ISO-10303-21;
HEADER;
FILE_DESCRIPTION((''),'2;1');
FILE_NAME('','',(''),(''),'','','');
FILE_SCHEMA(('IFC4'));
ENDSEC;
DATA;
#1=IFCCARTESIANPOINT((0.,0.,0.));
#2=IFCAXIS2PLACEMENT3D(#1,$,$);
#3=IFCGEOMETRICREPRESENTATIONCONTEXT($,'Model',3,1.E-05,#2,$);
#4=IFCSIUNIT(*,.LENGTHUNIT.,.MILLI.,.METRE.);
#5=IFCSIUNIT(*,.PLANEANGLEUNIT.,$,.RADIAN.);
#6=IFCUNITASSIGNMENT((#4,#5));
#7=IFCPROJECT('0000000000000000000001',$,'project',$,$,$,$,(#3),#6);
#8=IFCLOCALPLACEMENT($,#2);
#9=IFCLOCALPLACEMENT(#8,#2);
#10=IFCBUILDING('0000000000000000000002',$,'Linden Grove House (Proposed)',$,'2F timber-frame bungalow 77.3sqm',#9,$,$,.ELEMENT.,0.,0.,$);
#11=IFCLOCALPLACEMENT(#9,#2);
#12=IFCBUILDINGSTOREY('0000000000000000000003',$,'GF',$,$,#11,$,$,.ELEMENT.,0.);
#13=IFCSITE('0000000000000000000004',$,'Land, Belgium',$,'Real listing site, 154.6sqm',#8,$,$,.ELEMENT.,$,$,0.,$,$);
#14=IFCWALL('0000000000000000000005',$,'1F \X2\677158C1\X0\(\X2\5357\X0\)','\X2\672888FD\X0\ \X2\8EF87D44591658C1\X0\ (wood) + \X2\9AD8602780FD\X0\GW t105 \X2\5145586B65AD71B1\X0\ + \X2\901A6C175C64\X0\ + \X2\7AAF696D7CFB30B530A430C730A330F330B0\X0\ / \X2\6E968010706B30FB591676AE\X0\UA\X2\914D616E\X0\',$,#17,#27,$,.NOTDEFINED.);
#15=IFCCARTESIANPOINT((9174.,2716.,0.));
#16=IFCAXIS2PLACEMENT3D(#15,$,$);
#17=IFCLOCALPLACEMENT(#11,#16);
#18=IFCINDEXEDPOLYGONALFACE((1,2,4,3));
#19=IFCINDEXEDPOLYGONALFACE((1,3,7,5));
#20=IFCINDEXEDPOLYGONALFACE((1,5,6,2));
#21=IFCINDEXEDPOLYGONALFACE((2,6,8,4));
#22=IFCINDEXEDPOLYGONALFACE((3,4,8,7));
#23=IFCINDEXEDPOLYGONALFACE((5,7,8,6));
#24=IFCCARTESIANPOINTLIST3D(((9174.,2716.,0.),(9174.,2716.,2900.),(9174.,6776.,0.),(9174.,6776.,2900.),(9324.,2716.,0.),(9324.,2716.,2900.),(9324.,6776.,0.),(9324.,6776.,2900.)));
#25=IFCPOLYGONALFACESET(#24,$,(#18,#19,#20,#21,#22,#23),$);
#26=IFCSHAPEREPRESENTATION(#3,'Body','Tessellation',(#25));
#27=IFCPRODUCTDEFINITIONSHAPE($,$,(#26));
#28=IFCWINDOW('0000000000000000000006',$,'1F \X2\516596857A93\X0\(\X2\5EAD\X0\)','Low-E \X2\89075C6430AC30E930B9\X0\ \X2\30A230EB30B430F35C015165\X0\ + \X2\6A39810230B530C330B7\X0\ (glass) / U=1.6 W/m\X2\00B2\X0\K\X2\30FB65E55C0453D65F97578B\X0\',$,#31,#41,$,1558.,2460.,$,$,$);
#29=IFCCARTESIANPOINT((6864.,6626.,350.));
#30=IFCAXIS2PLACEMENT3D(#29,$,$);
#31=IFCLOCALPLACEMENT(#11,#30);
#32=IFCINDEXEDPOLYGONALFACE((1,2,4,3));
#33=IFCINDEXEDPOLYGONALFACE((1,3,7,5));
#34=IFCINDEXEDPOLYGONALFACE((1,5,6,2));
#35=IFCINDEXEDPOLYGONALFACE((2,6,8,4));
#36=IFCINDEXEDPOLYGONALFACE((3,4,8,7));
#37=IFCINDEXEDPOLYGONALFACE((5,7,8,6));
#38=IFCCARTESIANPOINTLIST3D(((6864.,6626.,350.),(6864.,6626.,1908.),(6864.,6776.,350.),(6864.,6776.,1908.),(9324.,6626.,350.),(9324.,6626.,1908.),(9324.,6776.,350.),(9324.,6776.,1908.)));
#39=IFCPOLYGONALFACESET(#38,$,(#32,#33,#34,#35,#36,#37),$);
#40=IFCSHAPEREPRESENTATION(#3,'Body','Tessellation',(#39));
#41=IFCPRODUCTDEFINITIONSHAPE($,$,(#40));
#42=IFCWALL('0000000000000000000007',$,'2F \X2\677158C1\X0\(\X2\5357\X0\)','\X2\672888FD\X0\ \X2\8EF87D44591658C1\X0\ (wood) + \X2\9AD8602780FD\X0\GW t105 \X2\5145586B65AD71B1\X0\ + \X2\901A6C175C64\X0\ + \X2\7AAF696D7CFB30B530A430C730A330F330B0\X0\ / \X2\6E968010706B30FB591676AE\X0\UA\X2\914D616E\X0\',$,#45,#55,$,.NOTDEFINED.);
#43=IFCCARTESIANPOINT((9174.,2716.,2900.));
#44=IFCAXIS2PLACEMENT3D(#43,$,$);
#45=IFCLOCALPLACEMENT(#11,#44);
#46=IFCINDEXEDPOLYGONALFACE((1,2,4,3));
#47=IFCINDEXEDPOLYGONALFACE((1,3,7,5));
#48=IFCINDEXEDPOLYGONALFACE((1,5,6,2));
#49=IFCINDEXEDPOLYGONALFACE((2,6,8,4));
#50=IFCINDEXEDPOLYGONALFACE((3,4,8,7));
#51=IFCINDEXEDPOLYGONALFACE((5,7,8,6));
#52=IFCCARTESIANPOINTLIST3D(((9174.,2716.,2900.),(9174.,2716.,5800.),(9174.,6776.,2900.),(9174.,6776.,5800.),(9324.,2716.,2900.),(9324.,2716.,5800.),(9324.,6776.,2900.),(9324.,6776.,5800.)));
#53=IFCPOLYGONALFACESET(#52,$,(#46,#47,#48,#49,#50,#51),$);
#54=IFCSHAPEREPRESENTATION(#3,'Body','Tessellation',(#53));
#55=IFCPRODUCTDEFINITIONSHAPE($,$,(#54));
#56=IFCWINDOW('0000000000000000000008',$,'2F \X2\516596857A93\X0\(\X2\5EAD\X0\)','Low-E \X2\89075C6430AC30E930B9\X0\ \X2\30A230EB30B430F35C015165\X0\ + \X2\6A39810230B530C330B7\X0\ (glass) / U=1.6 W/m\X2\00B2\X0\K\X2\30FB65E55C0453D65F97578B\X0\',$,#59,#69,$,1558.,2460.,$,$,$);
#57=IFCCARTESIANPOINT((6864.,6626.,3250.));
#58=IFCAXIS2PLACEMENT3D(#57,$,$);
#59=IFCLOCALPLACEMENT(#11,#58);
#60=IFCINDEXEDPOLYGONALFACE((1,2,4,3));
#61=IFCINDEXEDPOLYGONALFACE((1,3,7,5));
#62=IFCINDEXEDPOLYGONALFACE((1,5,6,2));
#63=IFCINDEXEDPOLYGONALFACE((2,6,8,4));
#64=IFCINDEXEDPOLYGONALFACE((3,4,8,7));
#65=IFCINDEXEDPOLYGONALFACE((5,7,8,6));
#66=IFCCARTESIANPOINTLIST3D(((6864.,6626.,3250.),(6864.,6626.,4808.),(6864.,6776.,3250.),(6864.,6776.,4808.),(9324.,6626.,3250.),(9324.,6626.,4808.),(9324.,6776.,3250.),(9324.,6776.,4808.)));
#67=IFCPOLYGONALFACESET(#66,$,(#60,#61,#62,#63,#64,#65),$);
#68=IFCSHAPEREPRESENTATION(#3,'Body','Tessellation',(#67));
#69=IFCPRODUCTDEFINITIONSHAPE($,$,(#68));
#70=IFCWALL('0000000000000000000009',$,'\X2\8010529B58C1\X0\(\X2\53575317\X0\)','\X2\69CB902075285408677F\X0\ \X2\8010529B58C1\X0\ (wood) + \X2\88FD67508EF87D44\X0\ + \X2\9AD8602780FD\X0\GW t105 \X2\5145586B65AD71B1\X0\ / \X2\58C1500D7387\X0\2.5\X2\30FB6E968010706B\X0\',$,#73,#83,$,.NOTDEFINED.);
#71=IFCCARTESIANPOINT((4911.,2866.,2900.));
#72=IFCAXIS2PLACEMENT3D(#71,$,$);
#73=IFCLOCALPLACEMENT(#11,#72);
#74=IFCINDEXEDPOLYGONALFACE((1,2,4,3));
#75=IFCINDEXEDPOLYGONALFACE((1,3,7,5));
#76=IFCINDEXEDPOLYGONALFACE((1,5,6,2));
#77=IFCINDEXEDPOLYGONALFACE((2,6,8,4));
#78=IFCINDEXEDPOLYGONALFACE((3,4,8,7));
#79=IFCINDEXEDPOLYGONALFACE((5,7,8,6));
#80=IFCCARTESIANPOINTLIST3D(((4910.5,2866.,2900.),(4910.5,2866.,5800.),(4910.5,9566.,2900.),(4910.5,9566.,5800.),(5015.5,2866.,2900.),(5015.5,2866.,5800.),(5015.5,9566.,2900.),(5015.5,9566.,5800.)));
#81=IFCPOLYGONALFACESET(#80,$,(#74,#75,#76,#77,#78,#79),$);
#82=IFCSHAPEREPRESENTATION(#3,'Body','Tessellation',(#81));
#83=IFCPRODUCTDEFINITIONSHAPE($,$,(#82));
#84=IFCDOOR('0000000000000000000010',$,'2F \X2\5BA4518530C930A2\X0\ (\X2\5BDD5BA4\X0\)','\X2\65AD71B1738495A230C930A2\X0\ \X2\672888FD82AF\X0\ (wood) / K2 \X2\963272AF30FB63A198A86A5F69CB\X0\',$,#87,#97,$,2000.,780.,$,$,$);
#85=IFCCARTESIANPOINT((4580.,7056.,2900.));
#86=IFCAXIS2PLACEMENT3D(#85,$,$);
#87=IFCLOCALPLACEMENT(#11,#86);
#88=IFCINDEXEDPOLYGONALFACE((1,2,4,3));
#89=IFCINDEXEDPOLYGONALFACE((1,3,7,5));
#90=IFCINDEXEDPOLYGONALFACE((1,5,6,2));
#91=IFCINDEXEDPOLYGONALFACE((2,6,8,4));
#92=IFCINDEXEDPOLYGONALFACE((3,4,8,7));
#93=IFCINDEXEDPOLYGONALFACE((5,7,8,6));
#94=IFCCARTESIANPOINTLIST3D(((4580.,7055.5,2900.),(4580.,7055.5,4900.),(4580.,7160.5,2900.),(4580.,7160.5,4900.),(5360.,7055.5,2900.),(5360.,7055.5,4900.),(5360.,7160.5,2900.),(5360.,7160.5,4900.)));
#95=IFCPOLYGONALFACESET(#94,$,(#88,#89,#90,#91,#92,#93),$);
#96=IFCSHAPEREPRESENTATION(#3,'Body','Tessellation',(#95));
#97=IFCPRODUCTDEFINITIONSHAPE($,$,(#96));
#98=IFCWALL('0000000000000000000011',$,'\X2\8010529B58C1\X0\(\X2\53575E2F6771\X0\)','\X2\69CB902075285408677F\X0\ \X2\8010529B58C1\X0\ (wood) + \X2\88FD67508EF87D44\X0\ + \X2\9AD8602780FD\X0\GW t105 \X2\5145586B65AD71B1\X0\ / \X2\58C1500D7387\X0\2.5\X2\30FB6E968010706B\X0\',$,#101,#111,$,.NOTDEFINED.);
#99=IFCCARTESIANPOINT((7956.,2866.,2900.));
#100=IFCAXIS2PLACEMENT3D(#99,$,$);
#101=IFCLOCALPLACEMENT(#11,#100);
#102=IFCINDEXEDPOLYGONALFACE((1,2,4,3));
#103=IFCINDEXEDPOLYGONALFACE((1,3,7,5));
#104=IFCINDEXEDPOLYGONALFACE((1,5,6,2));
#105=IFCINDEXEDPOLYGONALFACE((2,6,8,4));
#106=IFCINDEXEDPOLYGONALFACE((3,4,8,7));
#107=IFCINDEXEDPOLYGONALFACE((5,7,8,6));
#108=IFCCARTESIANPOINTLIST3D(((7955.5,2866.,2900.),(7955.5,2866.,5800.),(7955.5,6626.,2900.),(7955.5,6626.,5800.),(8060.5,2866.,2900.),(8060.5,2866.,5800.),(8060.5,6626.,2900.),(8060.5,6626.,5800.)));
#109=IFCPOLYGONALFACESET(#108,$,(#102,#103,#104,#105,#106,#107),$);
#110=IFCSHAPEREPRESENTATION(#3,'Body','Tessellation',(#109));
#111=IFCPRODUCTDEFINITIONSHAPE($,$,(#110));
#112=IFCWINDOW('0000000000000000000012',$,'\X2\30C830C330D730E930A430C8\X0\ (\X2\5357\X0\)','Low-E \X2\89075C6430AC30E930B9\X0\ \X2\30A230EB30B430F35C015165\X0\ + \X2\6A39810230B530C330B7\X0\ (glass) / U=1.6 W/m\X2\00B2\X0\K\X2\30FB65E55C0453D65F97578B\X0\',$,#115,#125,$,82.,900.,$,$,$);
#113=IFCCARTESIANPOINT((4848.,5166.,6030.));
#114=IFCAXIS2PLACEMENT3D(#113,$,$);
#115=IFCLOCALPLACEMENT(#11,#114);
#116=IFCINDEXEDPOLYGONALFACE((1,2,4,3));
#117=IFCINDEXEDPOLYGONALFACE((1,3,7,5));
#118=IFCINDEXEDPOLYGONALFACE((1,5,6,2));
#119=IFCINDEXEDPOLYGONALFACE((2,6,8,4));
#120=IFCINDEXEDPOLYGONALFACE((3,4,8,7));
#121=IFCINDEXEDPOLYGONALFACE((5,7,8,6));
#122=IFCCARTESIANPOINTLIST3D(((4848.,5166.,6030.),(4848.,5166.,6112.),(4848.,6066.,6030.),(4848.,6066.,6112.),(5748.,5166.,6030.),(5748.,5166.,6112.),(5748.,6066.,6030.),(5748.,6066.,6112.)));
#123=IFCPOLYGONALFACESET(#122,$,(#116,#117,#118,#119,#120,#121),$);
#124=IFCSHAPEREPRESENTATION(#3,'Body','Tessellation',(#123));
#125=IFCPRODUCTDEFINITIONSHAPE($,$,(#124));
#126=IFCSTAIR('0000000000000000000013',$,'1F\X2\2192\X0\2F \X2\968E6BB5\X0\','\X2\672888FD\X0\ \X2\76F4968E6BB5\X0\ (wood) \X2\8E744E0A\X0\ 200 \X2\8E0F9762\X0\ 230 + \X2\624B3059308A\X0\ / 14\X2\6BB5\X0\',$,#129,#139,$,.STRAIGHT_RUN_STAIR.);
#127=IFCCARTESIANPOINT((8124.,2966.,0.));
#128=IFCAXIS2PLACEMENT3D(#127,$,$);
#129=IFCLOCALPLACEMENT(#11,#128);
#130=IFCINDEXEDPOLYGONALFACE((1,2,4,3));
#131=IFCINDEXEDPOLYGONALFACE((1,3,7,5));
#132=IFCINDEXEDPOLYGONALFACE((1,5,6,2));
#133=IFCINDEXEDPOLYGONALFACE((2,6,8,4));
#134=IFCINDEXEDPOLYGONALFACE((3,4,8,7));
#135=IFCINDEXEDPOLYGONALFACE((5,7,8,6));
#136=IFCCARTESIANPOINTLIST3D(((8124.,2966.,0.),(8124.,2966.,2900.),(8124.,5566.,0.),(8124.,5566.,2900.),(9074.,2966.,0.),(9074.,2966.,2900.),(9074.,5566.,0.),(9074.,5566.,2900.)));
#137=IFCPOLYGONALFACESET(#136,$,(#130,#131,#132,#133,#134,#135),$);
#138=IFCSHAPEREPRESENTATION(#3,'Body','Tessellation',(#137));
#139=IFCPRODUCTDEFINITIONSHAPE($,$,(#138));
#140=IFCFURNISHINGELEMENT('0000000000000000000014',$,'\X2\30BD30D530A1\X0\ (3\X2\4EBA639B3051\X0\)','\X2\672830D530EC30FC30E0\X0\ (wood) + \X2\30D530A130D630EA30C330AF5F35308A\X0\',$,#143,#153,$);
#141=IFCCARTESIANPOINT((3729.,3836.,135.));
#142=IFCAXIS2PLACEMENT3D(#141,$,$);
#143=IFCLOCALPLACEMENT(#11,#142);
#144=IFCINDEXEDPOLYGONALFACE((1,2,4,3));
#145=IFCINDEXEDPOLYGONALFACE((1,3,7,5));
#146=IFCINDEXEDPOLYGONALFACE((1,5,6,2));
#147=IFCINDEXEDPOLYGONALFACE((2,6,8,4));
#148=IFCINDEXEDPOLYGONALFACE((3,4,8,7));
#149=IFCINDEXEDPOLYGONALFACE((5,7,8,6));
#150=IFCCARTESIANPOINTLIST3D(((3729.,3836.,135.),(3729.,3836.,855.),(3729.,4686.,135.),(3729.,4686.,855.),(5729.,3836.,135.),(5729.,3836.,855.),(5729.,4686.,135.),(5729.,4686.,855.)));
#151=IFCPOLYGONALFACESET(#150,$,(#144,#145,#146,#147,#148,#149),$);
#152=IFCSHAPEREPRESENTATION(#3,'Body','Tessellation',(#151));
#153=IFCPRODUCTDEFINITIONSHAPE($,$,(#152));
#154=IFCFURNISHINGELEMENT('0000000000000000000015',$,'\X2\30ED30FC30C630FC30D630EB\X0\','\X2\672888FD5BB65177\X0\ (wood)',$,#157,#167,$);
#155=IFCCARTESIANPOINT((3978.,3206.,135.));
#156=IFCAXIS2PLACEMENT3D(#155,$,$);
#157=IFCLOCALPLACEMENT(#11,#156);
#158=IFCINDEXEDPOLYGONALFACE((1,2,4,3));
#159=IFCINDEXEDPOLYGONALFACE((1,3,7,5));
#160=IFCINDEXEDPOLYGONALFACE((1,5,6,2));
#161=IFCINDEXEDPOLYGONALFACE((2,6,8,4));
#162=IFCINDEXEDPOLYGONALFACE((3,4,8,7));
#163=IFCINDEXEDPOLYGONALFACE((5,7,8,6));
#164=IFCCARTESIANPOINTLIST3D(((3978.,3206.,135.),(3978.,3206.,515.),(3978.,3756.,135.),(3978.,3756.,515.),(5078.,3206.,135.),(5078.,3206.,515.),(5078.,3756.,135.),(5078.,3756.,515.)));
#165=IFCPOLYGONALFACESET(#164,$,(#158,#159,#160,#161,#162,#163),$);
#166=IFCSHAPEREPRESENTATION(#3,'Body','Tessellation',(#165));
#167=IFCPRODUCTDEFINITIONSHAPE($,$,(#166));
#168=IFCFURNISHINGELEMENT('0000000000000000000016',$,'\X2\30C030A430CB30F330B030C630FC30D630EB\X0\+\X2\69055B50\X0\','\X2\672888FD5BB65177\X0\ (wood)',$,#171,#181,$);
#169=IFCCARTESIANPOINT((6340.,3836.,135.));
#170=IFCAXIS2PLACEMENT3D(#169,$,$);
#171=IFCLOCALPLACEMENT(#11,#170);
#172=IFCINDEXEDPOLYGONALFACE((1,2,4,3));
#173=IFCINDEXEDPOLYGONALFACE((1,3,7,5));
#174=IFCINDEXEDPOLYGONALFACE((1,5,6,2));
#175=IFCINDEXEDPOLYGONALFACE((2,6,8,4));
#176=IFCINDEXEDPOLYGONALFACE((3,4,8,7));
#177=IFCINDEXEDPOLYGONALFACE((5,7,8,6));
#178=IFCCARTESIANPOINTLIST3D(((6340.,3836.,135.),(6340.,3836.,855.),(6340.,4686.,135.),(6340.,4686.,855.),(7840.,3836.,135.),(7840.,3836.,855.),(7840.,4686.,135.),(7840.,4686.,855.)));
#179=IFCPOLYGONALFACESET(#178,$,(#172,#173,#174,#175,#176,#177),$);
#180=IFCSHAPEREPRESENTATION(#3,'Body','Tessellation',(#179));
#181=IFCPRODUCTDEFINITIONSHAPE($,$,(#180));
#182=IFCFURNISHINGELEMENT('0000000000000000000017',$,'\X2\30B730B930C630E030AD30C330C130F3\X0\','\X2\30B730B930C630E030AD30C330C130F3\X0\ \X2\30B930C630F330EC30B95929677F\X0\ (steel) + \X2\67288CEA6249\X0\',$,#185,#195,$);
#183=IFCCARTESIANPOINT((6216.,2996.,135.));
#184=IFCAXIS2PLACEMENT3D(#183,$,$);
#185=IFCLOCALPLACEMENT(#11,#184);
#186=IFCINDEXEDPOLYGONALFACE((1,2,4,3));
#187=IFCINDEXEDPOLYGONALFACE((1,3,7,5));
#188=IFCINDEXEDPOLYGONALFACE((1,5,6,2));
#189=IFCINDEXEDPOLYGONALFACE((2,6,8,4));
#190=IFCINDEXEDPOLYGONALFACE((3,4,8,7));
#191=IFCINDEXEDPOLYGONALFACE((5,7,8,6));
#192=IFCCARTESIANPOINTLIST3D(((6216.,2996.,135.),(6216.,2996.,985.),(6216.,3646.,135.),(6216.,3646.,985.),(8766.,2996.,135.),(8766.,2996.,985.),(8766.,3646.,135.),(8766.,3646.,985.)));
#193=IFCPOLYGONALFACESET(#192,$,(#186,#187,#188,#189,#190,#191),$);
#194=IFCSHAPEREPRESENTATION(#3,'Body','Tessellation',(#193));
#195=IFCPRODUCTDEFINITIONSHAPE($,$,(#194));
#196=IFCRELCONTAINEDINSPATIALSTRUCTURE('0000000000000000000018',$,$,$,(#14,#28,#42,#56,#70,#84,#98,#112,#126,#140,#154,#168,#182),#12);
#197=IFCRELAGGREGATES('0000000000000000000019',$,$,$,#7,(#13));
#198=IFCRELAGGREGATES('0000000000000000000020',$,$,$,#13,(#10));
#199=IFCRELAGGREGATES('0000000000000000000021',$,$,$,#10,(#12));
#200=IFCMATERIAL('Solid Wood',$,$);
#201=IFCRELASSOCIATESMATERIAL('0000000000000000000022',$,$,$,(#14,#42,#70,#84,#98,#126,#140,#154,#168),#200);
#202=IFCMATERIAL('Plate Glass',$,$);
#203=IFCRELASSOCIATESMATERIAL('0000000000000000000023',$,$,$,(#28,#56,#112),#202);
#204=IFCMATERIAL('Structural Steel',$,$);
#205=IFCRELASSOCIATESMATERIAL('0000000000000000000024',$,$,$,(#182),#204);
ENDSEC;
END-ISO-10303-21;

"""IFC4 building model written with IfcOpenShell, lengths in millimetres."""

from ifc_helpers import new_model, si_unit, frame, frame_2d, origin, place, context, project, spatial, rectangle, extrude, material, element, fill, save


model = new_model("IFC4")

# Units and contexts
model_context = context("Model", 3, precision=1e-05, world=origin())
ifc_project = project(units=[si_unit("LENGTHUNIT", "METRE", prefix="MILLI"), si_unit("PLANEANGLEUNIT", "RADIAN")], contexts=[model_context])

# Site, building, storey
site_placement = place(None, origin())
site = spatial("IfcSite", under=ifc_project, at=site_placement, Name="Land, Belgium", ObjectType="Real listing site, 154.6sqm", CompositionType="ELEMENT", RefElevation=0.0)
building_placement = place(site_placement, origin())
building = spatial("IfcBuilding", under=site, at=building_placement, Name="Linden Grove House (Proposed)", ObjectType="2F timber-frame bungalow 77.3sqm", CompositionType="ELEMENT", ElevationOfRefHeight=0.0, ElevationOfTerrain=0.0)
storey_placement = place(building_placement, origin())
storey = spatial("IfcBuildingStorey", under=building, at=storey_placement, Name="GF", CompositionType="ELEMENT", Elevation=0.0)

# Wall, opening, window
ifc_material_1 = material(Name="Solid Wood")
wall_1_placement = place(storey_placement, frame((9174.0, 2716.0, 0.0)))
wall_1 = element("IfcWall", 1, at=wall_1_placement, inside=storey, material=ifc_material_1, Name="1F 東壁(南)", Description="木製 軸組外壁 (wood) + 高性能GW t105 充填断熱 + 通気層 + 窯業系サイディング / 準耐火・外皮UA配慮", PredefinedType="NOTDEFINED", context=model_context, shape_type="SweptSolid", body=[
    extrude(rectangle(XDim=150.0, YDim=4060.0, at=frame_2d((75.0, 2030.0))), frame((9174.0, 2716.0, 0.0)), (0.0, 0.0, 1.0), 2900.0),
])
opening_1_placement = place(storey_placement, frame((6864.0, 6626.0, 350.0)))
opening_1 = element("IfcOpeningElement", 2, at=opening_1_placement, cuts=wall_1, PredefinedType="NOTDEFINED", context=model_context, shape_type="SweptSolid", body=[
    extrude(rectangle(XDim=2460.0, YDim=150.0, at=frame_2d((1230.0, 75.0))), frame((6864.0, 6626.0, 350.0)), (0.0, 0.0, 1.0), 1558.0),
])
ifc_material_2 = material(Name="Plate Glass")
window_1_placement = place(storey_placement, frame((6864.0, 6626.0, 350.0)))
window_1 = element("IfcWindow", 3, at=window_1_placement, inside=storey, material=ifc_material_2, Name="1F 入隅窓(庭)", Description="Low-E 複層ガラス アルゴン封入 + 樹脂サッシ (glass) / U=1.6 W/m²K・日射取得型", OverallHeight=1558.0, OverallWidth=2460.0, context=model_context, shape_type="SweptSolid", body=[
    extrude(rectangle(XDim=2460.0, YDim=150.0, at=frame_2d((1230.0, 75.0))), frame((6864.0, 6626.0, 350.0)), (0.0, 0.0, 1.0), 1558.0),
])
fill(opening_1, window_1)

# Wall, opening, window
wall_2_placement = place(storey_placement, frame((9174.0, 2716.0, 2900.0)))
wall_2 = element("IfcWall", 4, at=wall_2_placement, inside=storey, material=ifc_material_1, Name="2F 東壁(南)", Description="木製 軸組外壁 (wood) + 高性能GW t105 充填断熱 + 通気層 + 窯業系サイディング / 準耐火・外皮UA配慮", PredefinedType="NOTDEFINED", context=model_context, shape_type="SweptSolid", body=[
    extrude(rectangle(XDim=150.0, YDim=4060.0, at=frame_2d((75.0, 2030.0))), frame((9174.0, 2716.0, 2900.0)), (0.0, 0.0, 1.0), 2900.0),
])
opening_2_placement = place(storey_placement, frame((6864.0, 6626.0, 3250.0)))
opening_2 = element("IfcOpeningElement", 5, at=opening_2_placement, cuts=wall_2, PredefinedType="NOTDEFINED", context=model_context, shape_type="SweptSolid", body=[
    extrude(rectangle(XDim=2460.0, YDim=150.0, at=frame_2d((1230.0, 75.0))), frame((6864.0, 6626.0, 3250.0)), (0.0, 0.0, 1.0), 1558.0),
])
window_2_placement = place(storey_placement, frame((6864.0, 6626.0, 3250.0)))
window_2 = element("IfcWindow", 6, at=window_2_placement, inside=storey, material=ifc_material_2, Name="2F 入隅窓(庭)", Description="Low-E 複層ガラス アルゴン封入 + 樹脂サッシ (glass) / U=1.6 W/m²K・日射取得型", OverallHeight=1558.0, OverallWidth=2460.0, context=model_context, shape_type="SweptSolid", body=[
    extrude(rectangle(XDim=2460.0, YDim=150.0, at=frame_2d((1230.0, 75.0))), frame((6864.0, 6626.0, 3250.0)), (0.0, 0.0, 1.0), 1558.0),
])
fill(opening_2, window_2)

# Wall, opening, door
wall_3_placement = place(storey_placement, frame((4911.0, 2866.0, 2900.0)))
wall_3 = element("IfcWall", 7, at=wall_3_placement, inside=storey, material=ifc_material_1, Name="耐力壁(南北)", Description="構造用合板 耐力壁 (wood) + 製材軸組 + 高性能GW t105 充填断熱 / 壁倍率2.5・準耐火", PredefinedType="NOTDEFINED", context=model_context, shape_type="SweptSolid", body=[
    extrude(rectangle(XDim=105.0, YDim=6700.0, at=frame_2d((52.0, 3350.0))), frame((4911.0, 2866.0, 2900.0)), (0.0, 0.0, 1.0), 2900.0),
])
opening_3_placement = place(storey_placement, frame((4580.0, 7056.0, 2900.0)))
opening_3 = element("IfcOpeningElement", 8, at=opening_3_placement, cuts=wall_3, PredefinedType="NOTDEFINED", context=model_context, shape_type="SweptSolid", body=[
    extrude(rectangle(XDim=780.0, YDim=105.0, at=frame_2d((390.0, 52.0))), frame((4580.0, 7056.0, 2900.0)), (0.0, 0.0, 1.0), 2000.0),
])
door_1_placement = place(storey_placement, frame((4580.0, 7056.0, 2900.0)))
door_1 = element("IfcDoor", 9, at=door_1_placement, inside=storey, material=ifc_material_1, Name="2F 室内ドア (寝室)", Description="断熱玄関ドア 木製芯 (wood) / K2 防犯・採風機構", OverallHeight=2000.0, OverallWidth=780.0, context=model_context, shape_type="SweptSolid", body=[
    extrude(rectangle(XDim=780.0, YDim=105.0, at=frame_2d((390.0, 52.0))), frame((4580.0, 7056.0, 2900.0)), (0.0, 0.0, 1.0), 2000.0),
])
fill(opening_3, door_1)

# Wall
wall_4_placement = place(storey_placement, frame((7956.0, 2866.0, 2900.0)))
element("IfcWall", 10, at=wall_4_placement, inside=storey, material=ifc_material_1, Name="耐力壁(南帯東)", Description="構造用合板 耐力壁 (wood) + 製材軸組 + 高性能GW t105 充填断熱 / 壁倍率2.5・準耐火", PredefinedType="NOTDEFINED", context=model_context, shape_type="SweptSolid", body=[
    extrude(rectangle(XDim=105.0, YDim=3760.0, at=frame_2d((52.0, 1880.0))), frame((7956.0, 2866.0, 2900.0)), (0.0, 0.0, 1.0), 2900.0),
])

# Window
window_3_placement = place(storey_placement, frame((4848.0, 5166.0, 6030.0)))
element("IfcWindow", 11, at=window_3_placement, inside=storey, material=ifc_material_2, Name="トップライト (南)", Description="Low-E 複層ガラス アルゴン封入 + 樹脂サッシ (glass) / U=1.6 W/m²K・日射取得型", OverallHeight=82.0, OverallWidth=900.0, context=model_context, shape_type="SweptSolid", body=[
    extrude(rectangle(XDim=900.0, YDim=900.0, at=frame_2d((450.0, 450.0))), frame((4848.0, 5166.0, 6030.0)), (0.0, 0.0, 1.0), 82.0),
])

# Stair
stair_placement = place(storey_placement, frame((8124.0, 2966.0, 0.0)))
element("IfcStair", 12, at=stair_placement, inside=storey, material=ifc_material_1, Name="1F→2F 階段", Description="木製 直階段 (wood) 蹴上 200 踏面 230 + 手すり / 14段", PredefinedType="STRAIGHT_RUN_STAIR", context=model_context, shape_type="SweptSolid", body=[
    extrude(rectangle(XDim=950.0, YDim=2600.0, at=frame_2d((475.0, 1300.0))), frame((8124.0, 2966.0, 0.0)), (0.0, 0.0, 1.0), 2900.0),
])

# Furnishing elements
furnishing_1_placement = place(storey_placement, frame((3729.0, 3836.0, 135.0)))
element("IfcFurnishingElement", 13, at=furnishing_1_placement, inside=storey, material=ifc_material_1, Name="ソファ (3人掛け)", Description="木フレーム (wood) + ファブリック張り", context=model_context, shape_type="SweptSolid", body=[
    extrude(rectangle(XDim=2000.0, YDim=850.0, at=frame_2d((1000.0, 425.0))), frame((3729.0, 3836.0, 135.0)), (0.0, 0.0, 1.0), 720.0),
])
furnishing_2_placement = place(storey_placement, frame((3978.0, 3206.0, 135.0)))
element("IfcFurnishingElement", 14, at=furnishing_2_placement, inside=storey, material=ifc_material_1, Name="ローテーブル", Description="木製家具 (wood)", context=model_context, shape_type="SweptSolid", body=[
    extrude(rectangle(XDim=1100.0, YDim=550.0, at=frame_2d((550.0, 275.0))), frame((3978.0, 3206.0, 135.0)), (0.0, 0.0, 1.0), 380.0),
])
furnishing_3_placement = place(storey_placement, frame((6340.0, 3836.0, 135.0)))
element("IfcFurnishingElement", 15, at=furnishing_3_placement, inside=storey, material=ifc_material_1, Name="ダイニングテーブル+椅子", Description="木製家具 (wood)", context=model_context, shape_type="SweptSolid", body=[
    extrude(rectangle(XDim=1500.0, YDim=850.0, at=frame_2d((750.0, 425.0))), frame((6340.0, 3836.0, 135.0)), (0.0, 0.0, 1.0), 720.0),
])
ifc_material_3 = material(Name="Structural Steel")
furnishing_4_placement = place(storey_placement, frame((6216.0, 2996.0, 135.0)))
element("IfcFurnishingElement", 16, at=furnishing_4_placement, inside=storey, material=ifc_material_3, Name="システムキッチン", Description="システムキッチン ステンレス天板 (steel) + 木質扉", context=model_context, shape_type="SweptSolid", body=[
    extrude(rectangle(XDim=2550.0, YDim=650.0, at=frame_2d((1275.0, 325.0))), frame((6216.0, 2996.0, 135.0)), (0.0, 0.0, 1.0), 850.0),
])

save(model, "model.ifc")
